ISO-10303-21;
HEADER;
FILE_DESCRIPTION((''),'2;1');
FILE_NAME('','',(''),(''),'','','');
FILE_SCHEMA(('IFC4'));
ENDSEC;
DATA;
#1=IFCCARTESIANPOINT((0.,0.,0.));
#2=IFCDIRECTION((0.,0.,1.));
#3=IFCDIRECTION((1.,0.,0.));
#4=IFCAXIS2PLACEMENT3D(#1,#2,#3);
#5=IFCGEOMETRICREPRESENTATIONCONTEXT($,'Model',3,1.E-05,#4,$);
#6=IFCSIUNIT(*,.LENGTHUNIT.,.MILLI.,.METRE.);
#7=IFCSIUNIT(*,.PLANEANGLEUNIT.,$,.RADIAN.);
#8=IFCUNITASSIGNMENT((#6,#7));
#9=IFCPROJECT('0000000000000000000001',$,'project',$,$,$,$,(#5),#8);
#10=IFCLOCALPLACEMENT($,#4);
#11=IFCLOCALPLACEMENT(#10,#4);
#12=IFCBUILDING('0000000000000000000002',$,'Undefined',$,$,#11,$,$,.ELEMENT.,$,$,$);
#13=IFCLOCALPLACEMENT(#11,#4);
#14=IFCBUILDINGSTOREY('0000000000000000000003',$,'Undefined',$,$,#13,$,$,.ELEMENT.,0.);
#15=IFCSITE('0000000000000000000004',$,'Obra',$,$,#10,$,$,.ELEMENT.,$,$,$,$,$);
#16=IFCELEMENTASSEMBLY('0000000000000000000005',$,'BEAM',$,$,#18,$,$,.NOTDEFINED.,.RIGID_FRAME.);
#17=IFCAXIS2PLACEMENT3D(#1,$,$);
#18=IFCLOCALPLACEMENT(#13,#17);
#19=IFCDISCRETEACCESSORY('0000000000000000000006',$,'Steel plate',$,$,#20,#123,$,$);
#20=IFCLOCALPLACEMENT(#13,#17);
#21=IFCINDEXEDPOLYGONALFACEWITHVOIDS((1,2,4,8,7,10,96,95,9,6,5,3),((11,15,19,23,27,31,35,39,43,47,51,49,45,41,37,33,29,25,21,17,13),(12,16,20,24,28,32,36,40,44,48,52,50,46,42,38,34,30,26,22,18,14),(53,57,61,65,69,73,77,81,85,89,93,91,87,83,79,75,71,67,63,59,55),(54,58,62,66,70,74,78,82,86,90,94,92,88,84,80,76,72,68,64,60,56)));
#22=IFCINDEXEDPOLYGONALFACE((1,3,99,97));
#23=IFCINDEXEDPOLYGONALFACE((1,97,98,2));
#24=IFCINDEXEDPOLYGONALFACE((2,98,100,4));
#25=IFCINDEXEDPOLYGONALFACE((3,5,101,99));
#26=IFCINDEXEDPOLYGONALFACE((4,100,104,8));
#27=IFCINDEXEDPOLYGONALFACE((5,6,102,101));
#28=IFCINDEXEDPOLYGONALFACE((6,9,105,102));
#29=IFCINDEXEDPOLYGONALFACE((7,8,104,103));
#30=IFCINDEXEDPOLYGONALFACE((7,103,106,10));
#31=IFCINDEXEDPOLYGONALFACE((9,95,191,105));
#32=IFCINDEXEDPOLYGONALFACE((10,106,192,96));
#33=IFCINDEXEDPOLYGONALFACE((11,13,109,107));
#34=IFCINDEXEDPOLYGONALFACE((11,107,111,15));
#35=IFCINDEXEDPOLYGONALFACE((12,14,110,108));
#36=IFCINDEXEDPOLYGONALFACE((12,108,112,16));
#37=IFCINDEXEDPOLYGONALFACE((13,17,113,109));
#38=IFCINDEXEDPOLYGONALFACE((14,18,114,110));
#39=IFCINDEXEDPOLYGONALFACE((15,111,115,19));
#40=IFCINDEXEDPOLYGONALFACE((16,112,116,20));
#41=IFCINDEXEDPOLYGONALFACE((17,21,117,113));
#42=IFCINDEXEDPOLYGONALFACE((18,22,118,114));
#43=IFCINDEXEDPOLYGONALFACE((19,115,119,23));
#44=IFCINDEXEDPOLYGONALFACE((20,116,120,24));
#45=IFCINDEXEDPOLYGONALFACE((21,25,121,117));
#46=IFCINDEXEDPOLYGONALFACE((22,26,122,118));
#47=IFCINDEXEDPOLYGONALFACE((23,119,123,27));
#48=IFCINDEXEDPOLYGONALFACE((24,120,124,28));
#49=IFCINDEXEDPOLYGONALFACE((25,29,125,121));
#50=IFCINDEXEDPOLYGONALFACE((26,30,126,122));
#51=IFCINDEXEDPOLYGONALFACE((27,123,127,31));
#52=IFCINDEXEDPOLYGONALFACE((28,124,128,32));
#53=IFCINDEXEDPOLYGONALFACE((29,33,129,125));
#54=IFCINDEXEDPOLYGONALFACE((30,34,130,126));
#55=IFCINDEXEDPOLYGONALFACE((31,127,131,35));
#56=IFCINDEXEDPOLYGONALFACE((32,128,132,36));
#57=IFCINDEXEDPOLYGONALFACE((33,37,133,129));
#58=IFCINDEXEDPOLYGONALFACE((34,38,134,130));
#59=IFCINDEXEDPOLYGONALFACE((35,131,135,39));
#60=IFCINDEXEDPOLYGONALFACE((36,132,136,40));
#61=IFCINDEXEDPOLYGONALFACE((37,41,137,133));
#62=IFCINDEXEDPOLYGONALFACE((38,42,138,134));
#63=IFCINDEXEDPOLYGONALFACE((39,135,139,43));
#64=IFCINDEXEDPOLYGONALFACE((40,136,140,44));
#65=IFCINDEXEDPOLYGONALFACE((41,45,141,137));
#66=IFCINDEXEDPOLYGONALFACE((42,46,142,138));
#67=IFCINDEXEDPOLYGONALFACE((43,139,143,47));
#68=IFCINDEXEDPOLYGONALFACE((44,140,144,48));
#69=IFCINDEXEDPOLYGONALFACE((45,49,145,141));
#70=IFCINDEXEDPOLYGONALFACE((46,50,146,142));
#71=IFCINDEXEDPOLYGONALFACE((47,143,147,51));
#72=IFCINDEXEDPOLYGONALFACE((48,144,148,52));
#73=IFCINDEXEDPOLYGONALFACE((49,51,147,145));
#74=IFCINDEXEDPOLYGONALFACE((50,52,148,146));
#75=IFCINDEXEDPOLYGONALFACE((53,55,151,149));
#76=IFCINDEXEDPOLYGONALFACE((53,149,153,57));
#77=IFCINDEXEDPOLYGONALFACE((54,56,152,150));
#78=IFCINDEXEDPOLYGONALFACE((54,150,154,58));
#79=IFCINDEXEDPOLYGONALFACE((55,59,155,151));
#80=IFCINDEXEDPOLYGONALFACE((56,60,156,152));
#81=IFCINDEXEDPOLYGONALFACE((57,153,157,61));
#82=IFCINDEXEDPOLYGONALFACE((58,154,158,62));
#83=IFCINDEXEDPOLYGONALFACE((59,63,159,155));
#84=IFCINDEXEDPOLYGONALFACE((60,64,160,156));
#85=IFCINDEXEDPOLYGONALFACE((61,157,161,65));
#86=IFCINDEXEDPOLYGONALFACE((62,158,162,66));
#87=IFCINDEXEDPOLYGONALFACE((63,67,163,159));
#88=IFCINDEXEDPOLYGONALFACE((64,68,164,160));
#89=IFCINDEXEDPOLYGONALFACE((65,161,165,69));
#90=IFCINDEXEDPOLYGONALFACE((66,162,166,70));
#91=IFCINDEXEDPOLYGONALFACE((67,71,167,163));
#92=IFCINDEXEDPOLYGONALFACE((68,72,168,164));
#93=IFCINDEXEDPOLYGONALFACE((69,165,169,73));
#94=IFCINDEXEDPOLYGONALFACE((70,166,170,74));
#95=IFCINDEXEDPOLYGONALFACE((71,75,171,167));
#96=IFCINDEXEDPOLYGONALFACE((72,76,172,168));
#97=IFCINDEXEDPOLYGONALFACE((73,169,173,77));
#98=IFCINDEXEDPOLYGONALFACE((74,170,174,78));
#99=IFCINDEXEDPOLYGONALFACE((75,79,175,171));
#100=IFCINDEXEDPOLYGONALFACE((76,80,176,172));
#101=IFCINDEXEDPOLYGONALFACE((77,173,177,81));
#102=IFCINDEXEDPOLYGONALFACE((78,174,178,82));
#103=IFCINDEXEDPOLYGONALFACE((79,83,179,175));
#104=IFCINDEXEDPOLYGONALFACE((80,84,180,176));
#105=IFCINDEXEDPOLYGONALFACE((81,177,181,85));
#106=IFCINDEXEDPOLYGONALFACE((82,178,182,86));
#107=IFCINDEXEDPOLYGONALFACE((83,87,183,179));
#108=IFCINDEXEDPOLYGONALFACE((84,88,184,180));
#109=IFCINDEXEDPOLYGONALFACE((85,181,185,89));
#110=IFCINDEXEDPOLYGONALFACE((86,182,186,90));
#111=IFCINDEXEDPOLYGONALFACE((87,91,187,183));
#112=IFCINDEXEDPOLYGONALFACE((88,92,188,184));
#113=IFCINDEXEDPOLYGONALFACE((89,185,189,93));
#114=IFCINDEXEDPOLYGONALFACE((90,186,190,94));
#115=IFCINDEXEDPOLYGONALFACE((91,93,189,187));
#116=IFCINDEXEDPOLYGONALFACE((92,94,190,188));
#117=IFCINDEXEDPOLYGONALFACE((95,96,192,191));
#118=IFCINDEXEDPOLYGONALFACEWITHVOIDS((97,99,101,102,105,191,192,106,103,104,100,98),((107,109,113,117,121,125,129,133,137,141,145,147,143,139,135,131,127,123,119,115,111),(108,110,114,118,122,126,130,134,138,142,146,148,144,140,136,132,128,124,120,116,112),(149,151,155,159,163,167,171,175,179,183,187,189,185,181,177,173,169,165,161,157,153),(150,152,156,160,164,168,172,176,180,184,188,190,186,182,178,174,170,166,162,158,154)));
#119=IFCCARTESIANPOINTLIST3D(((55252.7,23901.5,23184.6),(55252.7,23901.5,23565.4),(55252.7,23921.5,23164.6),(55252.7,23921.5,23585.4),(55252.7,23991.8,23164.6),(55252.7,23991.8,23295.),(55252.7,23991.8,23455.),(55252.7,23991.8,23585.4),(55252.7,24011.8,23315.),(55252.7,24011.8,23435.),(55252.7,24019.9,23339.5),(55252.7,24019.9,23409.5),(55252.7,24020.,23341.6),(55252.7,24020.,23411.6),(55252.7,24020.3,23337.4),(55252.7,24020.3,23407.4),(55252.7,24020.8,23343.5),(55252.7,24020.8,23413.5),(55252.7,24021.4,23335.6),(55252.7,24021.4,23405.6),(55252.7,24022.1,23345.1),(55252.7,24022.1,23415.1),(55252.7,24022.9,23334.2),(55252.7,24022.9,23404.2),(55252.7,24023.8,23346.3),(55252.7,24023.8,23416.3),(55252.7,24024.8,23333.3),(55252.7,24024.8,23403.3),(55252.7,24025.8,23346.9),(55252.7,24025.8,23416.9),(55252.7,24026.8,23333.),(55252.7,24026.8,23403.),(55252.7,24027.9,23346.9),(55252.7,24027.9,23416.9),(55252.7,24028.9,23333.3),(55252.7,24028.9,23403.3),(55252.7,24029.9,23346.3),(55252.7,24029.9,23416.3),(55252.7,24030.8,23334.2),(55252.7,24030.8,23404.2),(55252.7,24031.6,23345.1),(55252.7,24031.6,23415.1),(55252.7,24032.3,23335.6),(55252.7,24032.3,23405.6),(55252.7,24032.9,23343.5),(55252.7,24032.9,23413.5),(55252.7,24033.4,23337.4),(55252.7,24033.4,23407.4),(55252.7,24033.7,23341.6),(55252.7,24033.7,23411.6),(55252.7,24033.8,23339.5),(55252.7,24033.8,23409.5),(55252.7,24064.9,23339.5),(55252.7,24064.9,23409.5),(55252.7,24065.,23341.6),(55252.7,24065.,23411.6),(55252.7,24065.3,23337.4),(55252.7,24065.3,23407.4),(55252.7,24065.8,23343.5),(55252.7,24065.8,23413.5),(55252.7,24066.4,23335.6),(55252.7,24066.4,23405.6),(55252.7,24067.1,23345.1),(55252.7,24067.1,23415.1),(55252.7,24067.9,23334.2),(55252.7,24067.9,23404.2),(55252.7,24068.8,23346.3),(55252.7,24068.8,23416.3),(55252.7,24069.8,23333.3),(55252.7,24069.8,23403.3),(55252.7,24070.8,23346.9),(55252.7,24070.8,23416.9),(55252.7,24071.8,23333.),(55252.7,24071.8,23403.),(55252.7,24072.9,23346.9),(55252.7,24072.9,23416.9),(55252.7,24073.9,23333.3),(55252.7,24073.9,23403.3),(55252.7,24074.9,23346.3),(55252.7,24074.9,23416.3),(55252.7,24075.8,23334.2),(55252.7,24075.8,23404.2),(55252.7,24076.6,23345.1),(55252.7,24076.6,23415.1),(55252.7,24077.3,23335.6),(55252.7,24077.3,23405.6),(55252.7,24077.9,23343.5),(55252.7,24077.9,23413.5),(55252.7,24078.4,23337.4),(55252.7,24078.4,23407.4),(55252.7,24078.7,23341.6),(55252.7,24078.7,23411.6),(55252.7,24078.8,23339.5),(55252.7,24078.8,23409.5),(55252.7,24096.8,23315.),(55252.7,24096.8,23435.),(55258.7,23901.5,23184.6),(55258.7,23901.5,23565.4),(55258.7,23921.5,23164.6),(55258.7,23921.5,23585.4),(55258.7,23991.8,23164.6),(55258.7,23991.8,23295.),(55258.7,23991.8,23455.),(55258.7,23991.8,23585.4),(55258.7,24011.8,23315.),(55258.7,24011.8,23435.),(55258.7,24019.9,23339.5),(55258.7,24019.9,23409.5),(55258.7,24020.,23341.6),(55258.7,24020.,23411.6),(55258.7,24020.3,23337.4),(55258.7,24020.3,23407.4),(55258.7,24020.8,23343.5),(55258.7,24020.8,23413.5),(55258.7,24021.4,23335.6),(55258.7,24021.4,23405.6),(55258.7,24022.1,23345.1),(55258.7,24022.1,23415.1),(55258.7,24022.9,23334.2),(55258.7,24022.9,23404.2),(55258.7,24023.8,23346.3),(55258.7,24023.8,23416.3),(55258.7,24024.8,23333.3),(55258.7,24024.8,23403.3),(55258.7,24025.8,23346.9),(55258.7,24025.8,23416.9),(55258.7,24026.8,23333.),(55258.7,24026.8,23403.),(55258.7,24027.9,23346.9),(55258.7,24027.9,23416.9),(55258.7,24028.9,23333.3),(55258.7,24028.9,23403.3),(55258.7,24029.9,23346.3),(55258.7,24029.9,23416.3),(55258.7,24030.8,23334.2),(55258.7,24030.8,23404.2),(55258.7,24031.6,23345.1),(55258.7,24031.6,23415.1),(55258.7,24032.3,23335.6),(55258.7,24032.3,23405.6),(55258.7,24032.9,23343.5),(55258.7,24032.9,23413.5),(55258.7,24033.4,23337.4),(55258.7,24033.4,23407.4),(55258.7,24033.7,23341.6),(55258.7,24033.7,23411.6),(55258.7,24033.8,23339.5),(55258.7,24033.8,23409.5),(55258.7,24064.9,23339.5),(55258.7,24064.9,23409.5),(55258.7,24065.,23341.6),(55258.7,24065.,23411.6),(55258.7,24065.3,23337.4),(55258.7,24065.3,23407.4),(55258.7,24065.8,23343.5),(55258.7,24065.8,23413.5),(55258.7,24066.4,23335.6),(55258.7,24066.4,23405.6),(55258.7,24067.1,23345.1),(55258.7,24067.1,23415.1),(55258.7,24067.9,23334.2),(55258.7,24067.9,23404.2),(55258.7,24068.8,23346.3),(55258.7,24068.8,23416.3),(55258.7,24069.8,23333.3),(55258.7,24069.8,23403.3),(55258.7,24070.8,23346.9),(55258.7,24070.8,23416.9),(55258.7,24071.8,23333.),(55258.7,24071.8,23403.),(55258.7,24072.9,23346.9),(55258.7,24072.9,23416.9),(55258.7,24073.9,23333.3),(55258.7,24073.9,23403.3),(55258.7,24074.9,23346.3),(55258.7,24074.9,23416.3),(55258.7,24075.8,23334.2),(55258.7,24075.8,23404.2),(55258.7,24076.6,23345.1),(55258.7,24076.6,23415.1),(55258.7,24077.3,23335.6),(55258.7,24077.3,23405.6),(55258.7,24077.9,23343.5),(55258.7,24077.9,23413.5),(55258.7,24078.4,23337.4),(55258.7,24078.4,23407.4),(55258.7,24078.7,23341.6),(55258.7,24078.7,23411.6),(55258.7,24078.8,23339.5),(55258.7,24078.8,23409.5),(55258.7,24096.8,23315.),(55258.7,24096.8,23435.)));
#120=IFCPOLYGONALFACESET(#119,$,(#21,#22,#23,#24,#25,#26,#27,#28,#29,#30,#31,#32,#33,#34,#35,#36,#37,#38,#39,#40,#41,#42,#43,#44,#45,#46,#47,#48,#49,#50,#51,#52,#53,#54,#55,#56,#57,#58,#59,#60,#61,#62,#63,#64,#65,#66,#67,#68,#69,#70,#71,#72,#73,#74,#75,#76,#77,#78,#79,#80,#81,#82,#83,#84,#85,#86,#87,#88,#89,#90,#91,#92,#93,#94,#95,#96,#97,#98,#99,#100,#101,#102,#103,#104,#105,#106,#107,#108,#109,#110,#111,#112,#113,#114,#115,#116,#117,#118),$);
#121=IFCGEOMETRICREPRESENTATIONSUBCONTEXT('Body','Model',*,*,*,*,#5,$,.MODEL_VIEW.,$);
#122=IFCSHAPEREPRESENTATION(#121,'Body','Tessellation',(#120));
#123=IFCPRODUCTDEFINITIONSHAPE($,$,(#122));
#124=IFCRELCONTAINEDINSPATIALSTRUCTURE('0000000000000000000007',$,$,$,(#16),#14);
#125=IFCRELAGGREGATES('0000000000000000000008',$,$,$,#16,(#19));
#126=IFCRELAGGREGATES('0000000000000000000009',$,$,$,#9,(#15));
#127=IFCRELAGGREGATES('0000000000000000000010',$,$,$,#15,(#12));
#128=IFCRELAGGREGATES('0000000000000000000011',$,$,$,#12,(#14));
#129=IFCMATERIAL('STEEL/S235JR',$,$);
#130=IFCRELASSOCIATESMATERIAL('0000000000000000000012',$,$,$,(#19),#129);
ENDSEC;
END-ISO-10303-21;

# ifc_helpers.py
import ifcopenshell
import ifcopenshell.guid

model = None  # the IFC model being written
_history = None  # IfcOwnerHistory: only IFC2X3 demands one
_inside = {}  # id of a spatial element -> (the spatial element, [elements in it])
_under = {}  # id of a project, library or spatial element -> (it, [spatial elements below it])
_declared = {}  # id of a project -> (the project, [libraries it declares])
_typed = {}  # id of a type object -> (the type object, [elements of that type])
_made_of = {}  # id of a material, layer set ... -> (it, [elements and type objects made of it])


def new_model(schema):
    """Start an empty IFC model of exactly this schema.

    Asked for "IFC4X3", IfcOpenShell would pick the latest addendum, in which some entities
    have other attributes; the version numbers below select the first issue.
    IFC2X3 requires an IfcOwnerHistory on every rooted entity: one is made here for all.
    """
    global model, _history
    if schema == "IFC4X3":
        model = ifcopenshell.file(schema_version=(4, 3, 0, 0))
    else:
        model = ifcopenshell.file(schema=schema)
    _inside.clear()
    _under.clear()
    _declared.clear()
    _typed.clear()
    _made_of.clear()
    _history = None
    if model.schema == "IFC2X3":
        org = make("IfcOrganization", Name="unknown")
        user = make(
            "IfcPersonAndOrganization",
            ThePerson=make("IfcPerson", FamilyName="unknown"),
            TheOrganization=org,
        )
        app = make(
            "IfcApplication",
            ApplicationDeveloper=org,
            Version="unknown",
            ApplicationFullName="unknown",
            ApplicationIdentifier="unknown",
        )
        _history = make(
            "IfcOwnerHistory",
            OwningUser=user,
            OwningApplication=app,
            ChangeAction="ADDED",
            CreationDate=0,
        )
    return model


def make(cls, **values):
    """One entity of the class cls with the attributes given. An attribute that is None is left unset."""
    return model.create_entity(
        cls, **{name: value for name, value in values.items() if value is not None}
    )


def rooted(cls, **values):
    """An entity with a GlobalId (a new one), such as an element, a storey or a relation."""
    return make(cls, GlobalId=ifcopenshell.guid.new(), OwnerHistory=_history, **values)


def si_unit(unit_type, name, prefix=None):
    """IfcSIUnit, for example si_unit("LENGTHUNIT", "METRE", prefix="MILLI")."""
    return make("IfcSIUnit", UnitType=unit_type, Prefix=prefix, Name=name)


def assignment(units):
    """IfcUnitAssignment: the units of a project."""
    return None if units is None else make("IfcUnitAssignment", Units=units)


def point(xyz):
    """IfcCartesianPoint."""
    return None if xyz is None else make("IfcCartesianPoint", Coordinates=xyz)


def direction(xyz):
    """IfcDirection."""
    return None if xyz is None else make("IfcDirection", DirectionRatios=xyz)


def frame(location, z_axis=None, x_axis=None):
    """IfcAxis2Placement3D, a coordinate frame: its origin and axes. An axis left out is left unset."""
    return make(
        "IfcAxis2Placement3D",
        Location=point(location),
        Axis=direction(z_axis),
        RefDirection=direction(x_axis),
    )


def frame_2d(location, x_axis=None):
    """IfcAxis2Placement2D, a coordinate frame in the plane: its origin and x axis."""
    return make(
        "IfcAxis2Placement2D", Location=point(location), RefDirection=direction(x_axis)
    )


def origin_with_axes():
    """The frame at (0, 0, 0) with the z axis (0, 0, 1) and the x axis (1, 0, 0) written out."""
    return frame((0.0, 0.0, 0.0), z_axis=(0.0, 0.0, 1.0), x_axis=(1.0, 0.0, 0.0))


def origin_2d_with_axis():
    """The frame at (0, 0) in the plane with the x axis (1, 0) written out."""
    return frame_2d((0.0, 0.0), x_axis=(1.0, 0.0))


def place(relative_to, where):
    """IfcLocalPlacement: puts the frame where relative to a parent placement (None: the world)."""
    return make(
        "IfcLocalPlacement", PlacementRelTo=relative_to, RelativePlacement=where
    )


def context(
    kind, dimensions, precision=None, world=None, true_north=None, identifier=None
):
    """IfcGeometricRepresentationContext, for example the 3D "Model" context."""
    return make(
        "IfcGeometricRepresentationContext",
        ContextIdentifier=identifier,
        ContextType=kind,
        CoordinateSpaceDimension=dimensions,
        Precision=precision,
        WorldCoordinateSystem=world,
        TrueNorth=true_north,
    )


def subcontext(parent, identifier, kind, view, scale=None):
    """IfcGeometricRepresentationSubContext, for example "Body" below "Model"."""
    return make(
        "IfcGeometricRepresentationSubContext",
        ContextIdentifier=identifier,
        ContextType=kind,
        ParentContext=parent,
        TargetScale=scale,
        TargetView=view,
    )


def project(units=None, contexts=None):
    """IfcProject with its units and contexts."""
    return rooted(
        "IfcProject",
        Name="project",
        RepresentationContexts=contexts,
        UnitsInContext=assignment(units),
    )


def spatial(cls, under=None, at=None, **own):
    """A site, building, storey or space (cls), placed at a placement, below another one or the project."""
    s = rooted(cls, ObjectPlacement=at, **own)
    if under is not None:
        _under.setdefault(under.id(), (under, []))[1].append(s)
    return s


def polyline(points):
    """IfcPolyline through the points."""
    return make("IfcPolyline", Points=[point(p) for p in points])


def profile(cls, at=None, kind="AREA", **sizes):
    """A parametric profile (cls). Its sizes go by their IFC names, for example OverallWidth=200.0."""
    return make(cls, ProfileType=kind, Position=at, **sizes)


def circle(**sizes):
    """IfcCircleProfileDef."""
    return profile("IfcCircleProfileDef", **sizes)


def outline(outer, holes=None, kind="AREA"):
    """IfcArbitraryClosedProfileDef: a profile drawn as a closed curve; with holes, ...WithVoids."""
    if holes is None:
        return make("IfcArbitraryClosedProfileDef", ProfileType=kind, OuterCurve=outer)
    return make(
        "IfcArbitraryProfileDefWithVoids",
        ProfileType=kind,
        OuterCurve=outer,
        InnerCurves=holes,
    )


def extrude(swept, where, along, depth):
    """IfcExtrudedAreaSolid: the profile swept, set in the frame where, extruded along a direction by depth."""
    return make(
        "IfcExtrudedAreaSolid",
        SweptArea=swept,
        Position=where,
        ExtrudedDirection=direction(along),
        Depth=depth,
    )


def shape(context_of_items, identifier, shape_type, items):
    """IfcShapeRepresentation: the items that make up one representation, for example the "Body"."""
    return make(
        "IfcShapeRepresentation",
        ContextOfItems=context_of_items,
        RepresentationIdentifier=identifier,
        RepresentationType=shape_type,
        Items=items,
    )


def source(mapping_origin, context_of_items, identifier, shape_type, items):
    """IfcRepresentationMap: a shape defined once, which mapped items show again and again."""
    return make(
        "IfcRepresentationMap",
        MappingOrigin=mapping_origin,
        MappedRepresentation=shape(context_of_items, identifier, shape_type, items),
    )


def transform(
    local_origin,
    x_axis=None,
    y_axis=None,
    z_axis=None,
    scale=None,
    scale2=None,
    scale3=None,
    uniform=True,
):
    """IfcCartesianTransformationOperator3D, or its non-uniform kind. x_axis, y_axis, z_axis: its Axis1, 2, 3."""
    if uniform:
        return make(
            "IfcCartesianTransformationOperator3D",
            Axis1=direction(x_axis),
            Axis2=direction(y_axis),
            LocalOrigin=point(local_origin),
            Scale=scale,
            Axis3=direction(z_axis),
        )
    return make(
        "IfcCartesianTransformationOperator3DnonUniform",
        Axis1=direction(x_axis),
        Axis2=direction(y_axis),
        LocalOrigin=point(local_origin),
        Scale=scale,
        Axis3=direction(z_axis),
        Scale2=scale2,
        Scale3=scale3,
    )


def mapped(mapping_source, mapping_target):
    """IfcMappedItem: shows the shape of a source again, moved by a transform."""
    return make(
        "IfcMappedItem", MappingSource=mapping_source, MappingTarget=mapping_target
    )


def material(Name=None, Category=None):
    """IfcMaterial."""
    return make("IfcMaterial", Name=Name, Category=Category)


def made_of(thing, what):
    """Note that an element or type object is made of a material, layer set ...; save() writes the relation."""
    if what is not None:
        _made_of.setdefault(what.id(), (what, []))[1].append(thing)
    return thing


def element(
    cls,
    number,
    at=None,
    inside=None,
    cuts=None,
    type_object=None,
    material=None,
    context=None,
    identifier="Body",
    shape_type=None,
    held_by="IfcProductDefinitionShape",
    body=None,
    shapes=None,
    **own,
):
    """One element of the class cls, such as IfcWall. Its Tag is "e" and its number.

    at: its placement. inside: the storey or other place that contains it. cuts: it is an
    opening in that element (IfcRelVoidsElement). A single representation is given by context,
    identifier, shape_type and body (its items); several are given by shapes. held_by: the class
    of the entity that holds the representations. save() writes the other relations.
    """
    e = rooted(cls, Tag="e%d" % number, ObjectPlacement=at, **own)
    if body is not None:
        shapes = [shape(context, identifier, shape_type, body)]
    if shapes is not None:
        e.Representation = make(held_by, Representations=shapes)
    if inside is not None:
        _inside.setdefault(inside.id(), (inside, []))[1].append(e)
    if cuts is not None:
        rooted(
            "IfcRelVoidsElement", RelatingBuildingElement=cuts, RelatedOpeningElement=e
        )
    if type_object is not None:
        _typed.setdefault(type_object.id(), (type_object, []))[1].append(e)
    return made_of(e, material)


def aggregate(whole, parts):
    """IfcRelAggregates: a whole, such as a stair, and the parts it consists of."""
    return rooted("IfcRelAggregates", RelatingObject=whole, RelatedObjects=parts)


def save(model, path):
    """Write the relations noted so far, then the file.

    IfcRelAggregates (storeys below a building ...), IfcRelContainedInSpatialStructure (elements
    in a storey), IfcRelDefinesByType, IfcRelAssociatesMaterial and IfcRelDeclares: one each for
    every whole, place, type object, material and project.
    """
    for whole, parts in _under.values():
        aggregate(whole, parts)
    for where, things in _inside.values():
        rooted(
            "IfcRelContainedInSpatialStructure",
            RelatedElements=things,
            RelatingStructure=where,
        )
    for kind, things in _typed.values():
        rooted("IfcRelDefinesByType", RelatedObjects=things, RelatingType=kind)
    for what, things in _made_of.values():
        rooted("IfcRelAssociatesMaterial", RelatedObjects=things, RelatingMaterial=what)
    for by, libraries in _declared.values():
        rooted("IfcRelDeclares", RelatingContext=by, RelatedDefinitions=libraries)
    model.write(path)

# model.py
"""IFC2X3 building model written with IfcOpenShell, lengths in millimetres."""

from ifc_helpers import new_model, si_unit, frame, origin_with_axes, origin_2d_with_axis, place, context, subcontext, project, spatial, polyline, circle, outline, extrude, source, transform, mapped, material, element, aggregate, save


model = new_model("IFC2X3")

# Units and contexts
model_context = context("Model", 3, precision=1e-05, world=origin_with_axes())
body_context = subcontext(model_context, "Body", "Model", "MODEL_VIEW")
ifc_project = project(units=[si_unit("LENGTHUNIT", "METRE", prefix="MILLI"), si_unit("PLANEANGLEUNIT", "RADIAN")], contexts=[model_context])

# Site, building, storey
site_placement = place(None, origin_with_axes())
site = spatial("IfcSite", under=ifc_project, at=site_placement, Name="Obra", CompositionType="ELEMENT")
building_placement = place(site_placement, origin_with_axes())
building = spatial("IfcBuilding", under=site, at=building_placement, Name="Undefined", CompositionType="ELEMENT")
storey_placement = place(building_placement, origin_with_axes())
storey = spatial("IfcBuildingStorey", under=building, at=storey_placement, Name="Undefined", CompositionType="ELEMENT", Elevation=0.0)

# Shared definitions
ifc_material_1 = material(Name="STEEL/S235JR")

# Element assembly
assembly_1_placement = place(storey_placement, origin_with_axes())
assembly_1 = element("IfcElementAssembly", 1, at=assembly_1_placement, inside=storey, Name="BEAM", AssemblyPlace="NOTDEFINED", PredefinedType="RIGID_FRAME")
shared_shape_1 = source(origin_with_axes(), body_context, "Body", "SweptSolid", [
    extrude(circle(Radius=7.0, at=origin_2d_with_axis()), frame((0.0, -8.6, 0.0), z_axis=(0.0, 1.0, 0.0), x_axis=(1.0, 0.0, 0.0)), (0.0, 0.0, 1.0), 6.2),
])

# Discrete accessory, opening
discrete_accessory_1_placement = place(assembly_1_placement, frame((55255.7, 23901.5, 23184.6), z_axis=(1.0, 0.0, 0.0), x_axis=(0.0, 0.707107, -0.707107)))
discrete_accessory_1 = element("IfcDiscreteAccessory", 2, at=discrete_accessory_1_placement, material=ifc_material_1, Name="Steel plate", context=body_context, shape_type="SweptSolid", body=[
    extrude(outline(polyline([(0.0, 0.0), (28.3, 0.0), (78.0, 49.7), (-14.2, 141.9), (-14.2, 170.2), (45.9, 230.3), (-39.0, 315.2), (-99.1, 255.1), (-127.3, 255.1), (-219.6, 347.3), (-269.3, 297.6), (-269.3, 269.3), (0.0, 0.0)])), frame((0.0, 0.0, -3.0), z_axis=(0.0, 0.0, 1.0), x_axis=(1.0, 0.0, 0.0)), (0.0, 0.0, 1.0), 6.0),
])
opening_1_placement = place(assembly_1_placement, frame((55250.2, 24001.8, 23435.0), z_axis=(0.0, 1.0, 0.0), x_axis=(0.0, 0.0, -1.0)))
element("IfcOpeningElement", 3, at=opening_1_placement, cuts=discrete_accessory_1, ObjectType="Opening", context=body_context, shape_type="MappedRepresentation", body=[
    mapped(shared_shape_1, transform((25.0, 0.0, 25.0))),
    mapped(shared_shape_1, transform((25.0, 0.0, 70.0))),
    mapped(shared_shape_1, transform((95.0, 0.0, 25.0))),
    mapped(shared_shape_1, transform((95.0, 0.0, 70.0))),
])

aggregate(assembly_1, [discrete_accessory_1])

save(model, "model.ifc")
